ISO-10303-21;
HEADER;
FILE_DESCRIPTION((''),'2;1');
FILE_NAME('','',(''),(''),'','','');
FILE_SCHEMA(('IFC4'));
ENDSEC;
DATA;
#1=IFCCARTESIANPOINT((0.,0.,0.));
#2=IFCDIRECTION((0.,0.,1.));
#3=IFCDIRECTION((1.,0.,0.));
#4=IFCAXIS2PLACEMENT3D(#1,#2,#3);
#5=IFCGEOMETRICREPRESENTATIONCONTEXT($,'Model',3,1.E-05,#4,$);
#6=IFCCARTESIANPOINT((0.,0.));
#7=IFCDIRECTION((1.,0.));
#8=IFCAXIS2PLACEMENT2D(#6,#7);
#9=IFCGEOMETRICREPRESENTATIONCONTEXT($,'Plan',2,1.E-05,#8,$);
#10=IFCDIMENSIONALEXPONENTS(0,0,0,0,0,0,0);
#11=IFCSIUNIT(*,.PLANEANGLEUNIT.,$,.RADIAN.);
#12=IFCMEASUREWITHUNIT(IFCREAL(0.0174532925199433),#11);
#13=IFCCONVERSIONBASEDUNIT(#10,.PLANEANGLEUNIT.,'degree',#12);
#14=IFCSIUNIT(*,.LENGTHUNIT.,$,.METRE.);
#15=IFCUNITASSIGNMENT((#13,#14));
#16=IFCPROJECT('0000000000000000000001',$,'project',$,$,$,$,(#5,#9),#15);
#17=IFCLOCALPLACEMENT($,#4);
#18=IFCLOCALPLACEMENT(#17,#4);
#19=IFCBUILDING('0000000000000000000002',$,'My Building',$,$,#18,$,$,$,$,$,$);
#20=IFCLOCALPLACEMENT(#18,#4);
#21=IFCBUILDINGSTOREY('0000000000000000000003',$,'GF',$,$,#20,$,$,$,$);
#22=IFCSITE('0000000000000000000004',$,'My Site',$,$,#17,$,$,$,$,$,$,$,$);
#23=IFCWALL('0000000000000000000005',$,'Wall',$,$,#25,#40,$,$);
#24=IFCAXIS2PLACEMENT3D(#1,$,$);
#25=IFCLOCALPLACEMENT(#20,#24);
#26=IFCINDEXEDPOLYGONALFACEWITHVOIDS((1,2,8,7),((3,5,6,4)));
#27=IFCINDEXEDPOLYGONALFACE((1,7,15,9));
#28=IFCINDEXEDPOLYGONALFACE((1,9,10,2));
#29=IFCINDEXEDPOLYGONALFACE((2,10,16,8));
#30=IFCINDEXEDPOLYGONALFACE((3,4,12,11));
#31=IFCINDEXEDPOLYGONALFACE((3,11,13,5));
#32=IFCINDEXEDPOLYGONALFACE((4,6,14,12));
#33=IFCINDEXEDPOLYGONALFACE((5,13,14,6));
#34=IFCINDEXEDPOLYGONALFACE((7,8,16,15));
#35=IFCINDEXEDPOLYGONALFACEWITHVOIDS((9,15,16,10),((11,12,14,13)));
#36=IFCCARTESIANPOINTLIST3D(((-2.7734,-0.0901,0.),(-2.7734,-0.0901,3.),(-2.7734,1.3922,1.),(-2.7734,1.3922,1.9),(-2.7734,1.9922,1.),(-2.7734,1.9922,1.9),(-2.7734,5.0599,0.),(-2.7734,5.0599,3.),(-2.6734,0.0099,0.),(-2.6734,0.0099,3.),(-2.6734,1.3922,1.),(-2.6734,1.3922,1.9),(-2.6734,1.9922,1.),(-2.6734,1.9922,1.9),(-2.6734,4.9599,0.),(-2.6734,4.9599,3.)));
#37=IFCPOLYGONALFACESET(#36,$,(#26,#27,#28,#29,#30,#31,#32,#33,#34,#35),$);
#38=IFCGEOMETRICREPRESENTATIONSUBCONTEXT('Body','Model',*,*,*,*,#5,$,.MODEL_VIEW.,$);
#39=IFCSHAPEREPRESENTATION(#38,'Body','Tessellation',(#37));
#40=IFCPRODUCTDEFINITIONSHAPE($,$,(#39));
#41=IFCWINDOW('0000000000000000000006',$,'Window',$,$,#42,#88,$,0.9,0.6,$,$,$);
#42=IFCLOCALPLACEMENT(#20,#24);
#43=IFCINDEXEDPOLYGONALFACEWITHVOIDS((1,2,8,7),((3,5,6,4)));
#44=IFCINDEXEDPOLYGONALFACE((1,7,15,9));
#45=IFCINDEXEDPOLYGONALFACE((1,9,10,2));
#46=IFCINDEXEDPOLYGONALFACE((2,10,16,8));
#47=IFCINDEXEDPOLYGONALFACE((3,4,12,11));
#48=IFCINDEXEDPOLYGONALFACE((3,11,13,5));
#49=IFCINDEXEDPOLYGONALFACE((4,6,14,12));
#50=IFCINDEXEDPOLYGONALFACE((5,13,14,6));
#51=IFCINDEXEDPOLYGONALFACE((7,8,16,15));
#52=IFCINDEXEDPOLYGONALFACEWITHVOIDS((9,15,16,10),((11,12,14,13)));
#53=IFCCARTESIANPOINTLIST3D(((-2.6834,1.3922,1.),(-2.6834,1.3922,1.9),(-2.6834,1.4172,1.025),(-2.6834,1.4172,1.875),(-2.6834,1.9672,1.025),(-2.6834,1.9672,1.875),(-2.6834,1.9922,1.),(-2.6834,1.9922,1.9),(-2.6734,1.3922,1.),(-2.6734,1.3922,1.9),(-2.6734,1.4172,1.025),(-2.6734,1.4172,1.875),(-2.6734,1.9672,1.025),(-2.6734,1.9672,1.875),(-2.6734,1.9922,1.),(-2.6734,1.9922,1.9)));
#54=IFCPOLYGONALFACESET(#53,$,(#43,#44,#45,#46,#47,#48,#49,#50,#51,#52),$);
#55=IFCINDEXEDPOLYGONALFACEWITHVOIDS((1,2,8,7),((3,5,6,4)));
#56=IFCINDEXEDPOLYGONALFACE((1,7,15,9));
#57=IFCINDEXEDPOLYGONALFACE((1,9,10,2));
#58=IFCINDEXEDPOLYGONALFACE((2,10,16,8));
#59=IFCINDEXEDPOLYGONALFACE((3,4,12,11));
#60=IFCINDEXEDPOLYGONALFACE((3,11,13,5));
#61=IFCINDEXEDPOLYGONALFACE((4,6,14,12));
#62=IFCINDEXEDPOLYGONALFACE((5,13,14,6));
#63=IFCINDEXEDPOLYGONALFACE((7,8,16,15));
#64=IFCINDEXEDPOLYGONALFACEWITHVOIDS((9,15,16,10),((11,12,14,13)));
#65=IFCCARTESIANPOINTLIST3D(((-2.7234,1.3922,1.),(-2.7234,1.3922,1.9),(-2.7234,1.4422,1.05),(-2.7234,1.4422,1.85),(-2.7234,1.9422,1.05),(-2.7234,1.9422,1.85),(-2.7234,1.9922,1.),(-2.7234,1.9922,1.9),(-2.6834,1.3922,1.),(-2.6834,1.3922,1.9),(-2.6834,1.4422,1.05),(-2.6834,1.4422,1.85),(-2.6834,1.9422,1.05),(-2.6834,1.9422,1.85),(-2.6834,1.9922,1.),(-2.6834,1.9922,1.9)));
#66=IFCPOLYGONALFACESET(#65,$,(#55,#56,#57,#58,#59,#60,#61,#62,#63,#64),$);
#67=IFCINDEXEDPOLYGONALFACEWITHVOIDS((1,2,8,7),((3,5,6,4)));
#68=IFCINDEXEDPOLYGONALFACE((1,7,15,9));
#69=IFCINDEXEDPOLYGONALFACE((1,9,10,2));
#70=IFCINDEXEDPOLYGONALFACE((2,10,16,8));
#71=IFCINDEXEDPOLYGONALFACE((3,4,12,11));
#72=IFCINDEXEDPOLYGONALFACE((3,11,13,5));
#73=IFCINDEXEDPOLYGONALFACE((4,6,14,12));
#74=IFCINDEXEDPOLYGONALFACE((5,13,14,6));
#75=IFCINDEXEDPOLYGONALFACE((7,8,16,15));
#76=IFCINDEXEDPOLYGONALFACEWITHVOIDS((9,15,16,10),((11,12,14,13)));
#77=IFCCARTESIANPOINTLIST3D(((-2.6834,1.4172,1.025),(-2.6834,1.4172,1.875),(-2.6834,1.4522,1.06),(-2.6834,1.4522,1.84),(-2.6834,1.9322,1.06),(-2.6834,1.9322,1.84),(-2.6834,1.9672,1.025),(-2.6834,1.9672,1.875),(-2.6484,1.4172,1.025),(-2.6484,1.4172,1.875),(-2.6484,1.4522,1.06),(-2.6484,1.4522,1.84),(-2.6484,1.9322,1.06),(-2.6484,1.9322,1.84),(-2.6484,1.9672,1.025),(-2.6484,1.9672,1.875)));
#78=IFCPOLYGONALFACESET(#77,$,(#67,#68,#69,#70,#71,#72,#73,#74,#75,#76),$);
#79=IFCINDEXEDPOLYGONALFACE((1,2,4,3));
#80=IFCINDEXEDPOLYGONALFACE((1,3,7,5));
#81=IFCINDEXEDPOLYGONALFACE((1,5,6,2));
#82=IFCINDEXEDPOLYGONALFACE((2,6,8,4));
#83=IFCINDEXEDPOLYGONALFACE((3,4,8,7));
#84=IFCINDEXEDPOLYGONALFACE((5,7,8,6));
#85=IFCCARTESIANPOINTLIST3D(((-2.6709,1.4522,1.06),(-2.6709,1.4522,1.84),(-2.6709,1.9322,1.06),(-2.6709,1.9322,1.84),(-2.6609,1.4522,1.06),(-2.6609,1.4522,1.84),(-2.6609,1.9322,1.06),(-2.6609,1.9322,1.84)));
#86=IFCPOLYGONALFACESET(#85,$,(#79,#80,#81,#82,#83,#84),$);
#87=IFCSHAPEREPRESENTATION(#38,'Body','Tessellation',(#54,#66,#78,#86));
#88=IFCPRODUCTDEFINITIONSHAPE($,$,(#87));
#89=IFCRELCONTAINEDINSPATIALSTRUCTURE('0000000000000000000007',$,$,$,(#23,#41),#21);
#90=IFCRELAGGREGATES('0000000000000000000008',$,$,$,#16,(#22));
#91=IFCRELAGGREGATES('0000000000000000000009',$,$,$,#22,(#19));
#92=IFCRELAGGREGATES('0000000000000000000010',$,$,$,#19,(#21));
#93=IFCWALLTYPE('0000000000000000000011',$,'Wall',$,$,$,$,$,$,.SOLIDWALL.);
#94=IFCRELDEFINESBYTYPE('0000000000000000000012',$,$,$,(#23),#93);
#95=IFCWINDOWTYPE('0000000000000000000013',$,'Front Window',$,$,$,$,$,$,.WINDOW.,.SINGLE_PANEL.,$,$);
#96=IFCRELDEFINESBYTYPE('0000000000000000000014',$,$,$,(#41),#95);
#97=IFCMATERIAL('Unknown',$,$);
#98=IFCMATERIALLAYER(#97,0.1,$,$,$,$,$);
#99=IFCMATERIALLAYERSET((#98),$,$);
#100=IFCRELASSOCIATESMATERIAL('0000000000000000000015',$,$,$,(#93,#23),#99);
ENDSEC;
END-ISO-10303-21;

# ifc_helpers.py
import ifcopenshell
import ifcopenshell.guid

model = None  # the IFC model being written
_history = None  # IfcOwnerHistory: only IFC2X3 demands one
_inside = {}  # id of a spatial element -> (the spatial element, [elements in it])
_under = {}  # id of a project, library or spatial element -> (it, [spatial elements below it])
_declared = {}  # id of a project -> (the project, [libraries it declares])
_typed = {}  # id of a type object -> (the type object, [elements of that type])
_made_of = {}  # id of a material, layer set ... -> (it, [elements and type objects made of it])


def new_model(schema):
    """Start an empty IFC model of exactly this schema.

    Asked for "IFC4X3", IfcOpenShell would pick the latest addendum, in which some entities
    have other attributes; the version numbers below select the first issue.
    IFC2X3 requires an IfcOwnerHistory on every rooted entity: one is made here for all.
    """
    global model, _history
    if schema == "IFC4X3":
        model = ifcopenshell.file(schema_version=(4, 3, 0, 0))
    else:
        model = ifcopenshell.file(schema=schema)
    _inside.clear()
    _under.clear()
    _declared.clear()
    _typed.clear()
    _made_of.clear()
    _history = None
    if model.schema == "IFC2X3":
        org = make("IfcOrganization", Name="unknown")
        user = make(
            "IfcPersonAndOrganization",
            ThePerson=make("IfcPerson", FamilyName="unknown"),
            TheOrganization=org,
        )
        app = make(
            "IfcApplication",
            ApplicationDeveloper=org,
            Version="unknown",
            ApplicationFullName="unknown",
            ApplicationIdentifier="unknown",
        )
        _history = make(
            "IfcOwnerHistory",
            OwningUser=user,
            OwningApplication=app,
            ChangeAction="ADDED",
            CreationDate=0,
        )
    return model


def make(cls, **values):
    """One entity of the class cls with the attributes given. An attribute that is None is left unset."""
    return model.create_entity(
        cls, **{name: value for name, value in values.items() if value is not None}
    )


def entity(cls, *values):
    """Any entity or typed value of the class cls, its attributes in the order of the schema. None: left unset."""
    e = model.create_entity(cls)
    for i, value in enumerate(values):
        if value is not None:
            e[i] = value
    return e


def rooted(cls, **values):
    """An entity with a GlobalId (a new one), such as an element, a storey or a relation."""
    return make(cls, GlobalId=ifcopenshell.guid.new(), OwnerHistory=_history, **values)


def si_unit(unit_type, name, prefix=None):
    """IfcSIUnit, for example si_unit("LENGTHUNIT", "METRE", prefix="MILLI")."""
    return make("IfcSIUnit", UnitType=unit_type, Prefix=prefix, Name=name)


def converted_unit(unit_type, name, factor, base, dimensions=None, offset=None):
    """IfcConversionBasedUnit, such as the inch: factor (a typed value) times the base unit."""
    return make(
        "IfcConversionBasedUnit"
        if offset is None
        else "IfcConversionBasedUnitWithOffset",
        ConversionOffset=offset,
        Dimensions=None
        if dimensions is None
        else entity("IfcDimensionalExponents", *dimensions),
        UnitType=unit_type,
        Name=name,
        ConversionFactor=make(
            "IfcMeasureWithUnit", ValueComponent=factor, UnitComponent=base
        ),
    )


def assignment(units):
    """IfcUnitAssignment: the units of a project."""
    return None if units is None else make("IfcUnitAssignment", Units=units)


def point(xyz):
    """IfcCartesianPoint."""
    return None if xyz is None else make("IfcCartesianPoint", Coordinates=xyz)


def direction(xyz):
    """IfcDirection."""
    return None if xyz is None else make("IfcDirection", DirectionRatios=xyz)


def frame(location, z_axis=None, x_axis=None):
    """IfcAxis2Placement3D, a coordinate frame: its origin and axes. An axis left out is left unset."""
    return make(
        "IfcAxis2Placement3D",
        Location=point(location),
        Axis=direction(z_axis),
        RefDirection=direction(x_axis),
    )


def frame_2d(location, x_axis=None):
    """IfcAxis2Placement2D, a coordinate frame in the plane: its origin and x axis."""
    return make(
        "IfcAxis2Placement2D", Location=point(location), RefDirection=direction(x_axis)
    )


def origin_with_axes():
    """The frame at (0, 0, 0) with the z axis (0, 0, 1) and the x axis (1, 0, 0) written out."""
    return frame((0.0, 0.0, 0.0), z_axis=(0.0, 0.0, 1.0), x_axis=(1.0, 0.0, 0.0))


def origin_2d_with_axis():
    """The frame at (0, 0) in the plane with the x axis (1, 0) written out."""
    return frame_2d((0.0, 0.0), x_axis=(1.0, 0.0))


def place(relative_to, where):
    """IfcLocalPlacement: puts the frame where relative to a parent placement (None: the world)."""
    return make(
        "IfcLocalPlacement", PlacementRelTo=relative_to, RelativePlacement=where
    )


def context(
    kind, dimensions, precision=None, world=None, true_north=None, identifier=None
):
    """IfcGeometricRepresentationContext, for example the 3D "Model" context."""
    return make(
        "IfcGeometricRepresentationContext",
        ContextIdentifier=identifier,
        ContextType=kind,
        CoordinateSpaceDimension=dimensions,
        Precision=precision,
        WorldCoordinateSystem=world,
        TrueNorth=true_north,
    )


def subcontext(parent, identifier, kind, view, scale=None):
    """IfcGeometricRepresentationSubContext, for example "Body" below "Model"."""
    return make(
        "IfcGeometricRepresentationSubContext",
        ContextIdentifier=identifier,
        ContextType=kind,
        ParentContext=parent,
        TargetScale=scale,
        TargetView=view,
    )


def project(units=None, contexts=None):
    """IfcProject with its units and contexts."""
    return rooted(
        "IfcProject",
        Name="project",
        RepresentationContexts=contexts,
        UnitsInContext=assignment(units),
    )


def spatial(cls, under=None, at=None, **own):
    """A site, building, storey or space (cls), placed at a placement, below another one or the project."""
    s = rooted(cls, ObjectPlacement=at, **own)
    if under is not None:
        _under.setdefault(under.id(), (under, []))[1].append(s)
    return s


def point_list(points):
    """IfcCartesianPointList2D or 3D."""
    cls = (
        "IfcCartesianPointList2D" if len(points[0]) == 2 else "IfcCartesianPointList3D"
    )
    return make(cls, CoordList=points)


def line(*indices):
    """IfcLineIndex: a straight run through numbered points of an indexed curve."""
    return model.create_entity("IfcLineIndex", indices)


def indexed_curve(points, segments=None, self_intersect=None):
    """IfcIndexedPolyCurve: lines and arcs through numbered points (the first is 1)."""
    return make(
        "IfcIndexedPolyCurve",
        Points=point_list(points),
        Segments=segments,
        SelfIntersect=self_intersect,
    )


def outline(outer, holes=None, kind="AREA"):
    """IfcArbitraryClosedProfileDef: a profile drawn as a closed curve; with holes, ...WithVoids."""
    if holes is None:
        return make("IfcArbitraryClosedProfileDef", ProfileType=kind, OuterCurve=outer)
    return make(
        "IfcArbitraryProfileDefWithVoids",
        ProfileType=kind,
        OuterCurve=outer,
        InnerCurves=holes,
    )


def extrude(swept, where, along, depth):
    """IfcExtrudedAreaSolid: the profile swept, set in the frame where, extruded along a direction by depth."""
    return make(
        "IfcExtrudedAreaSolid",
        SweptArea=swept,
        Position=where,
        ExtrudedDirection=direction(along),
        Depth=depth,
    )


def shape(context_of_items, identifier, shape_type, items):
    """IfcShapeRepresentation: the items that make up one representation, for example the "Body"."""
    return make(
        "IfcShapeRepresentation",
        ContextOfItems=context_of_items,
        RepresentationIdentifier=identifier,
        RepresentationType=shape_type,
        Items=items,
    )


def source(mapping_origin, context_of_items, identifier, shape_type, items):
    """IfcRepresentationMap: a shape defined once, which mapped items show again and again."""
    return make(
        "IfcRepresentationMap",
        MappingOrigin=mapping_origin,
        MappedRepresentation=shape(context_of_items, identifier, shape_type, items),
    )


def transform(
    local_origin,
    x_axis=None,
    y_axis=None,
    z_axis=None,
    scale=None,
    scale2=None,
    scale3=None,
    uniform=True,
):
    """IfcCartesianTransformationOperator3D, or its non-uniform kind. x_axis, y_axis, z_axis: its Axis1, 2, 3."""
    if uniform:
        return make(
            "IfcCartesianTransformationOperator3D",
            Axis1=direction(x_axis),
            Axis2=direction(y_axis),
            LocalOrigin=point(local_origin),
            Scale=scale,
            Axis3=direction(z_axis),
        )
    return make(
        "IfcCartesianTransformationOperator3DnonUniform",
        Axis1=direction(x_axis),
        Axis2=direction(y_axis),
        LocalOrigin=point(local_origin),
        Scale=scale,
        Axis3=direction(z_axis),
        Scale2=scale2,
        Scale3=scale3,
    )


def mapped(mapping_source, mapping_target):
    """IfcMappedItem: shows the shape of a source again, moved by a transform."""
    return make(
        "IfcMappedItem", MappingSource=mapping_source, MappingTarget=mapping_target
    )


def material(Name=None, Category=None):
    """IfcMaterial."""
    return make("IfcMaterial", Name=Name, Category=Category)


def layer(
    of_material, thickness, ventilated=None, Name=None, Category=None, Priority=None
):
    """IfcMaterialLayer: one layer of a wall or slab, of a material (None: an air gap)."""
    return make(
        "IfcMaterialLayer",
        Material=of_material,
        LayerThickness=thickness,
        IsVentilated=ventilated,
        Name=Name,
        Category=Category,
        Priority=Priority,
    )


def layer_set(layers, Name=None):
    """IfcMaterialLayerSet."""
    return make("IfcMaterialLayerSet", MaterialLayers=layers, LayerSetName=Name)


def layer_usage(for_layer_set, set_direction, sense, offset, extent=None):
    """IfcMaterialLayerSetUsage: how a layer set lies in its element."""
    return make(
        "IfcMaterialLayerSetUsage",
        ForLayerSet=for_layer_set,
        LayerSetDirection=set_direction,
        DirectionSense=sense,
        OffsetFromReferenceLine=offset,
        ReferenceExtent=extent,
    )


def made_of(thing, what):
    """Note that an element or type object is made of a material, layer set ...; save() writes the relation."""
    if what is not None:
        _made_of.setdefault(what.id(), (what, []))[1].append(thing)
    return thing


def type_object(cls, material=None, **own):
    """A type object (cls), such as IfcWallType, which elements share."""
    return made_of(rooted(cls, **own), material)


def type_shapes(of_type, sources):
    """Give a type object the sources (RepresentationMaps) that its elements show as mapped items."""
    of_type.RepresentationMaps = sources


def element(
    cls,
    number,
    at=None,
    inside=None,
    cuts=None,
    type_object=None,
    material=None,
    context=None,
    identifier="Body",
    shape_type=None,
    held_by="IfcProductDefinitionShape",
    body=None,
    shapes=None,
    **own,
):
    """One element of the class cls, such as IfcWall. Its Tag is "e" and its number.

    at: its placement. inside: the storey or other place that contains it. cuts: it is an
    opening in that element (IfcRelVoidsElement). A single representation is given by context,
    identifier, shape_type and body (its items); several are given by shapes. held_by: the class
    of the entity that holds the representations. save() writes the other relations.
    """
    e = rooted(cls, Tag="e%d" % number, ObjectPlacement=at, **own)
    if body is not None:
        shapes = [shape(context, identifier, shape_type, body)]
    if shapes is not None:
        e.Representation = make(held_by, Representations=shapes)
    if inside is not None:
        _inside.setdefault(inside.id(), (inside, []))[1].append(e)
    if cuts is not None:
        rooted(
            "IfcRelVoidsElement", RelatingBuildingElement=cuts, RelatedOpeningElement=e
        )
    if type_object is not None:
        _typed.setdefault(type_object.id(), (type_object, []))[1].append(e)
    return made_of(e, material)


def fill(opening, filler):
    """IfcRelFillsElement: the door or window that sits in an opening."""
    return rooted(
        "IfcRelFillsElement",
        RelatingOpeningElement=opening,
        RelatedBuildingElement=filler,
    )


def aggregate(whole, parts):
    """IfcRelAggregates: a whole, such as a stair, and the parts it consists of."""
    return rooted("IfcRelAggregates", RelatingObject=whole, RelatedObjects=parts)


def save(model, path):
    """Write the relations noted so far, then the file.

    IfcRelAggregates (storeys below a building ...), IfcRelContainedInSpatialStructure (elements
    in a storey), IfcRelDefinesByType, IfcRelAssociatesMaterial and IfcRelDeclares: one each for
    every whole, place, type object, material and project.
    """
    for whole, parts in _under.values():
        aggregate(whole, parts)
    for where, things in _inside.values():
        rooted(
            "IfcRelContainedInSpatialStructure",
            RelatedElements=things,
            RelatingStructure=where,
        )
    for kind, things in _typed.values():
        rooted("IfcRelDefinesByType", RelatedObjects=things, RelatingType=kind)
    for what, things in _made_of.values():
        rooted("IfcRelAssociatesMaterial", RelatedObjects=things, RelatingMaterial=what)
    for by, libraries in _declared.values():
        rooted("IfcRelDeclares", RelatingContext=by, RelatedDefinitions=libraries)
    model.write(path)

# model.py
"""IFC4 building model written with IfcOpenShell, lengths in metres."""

from ifc_helpers import new_model, entity, si_unit, converted_unit, frame, origin_with_axes, origin_2d_with_axis, place, context, subcontext, project, spatial, line, indexed_curve, outline, extrude, shape, source, transform, mapped, material, layer, layer_set, layer_usage, type_object, type_shapes, element, fill, save


model = new_model("IFC4")

# Units and contexts
model_context = context("Model", 3, precision=1e-05, world=origin_with_axes())
plan_context = context("Plan", 2, precision=1e-05, world=origin_2d_with_axis())
body_context_1 = subcontext(model_context, "Body", "Model", "MODEL_VIEW")
body_context_2 = subcontext(plan_context, "Body", "Plan", "PLAN_VIEW")
ifc_project = project(units=[converted_unit("PLANEANGLEUNIT", "degree", entity("IfcReal", 0.0174532925199433), si_unit("PLANEANGLEUNIT", "RADIAN"), dimensions=[0, 0, 0, 0, 0, 0, 0]), si_unit("LENGTHUNIT", "METRE")], contexts=[model_context, plan_context])

# Site, building, storey
site_placement = place(None, origin_with_axes())
site = spatial("IfcSite", under=ifc_project, at=site_placement, Name="My Site")
building_placement = place(site_placement, origin_with_axes())
building = spatial("IfcBuilding", under=site, at=building_placement, Name="My Building")
storey_placement = place(building_placement, origin_with_axes())
storey = spatial("IfcBuildingStorey", under=building, at=storey_placement, Name="GF")

# Shared definitions
ifc_material = material(Name="Unknown")

# Shared definitions
ifc_layer_1 = layer(ifc_material, 0.1)
ifc_layer_set_1 = layer_set([ifc_layer_1])
wall_type = type_object("IfcWallType", Name="Wall", PredefinedType="SOLIDWALL", material=ifc_layer_set_1)
shared_shape_1 = source(origin_with_axes(), body_context_1, "Body", "SweptSolid", [
    extrude(outline(indexed_curve([(0.0, 0.0), (0.6, 0.0), (0.6, 0.9), (0.0, 0.9)], segments=[line(1, 2, 3, 4, 1)])), frame((0.0, -0.6, 0.0), z_axis=(0.0, -1.0, 0.0), x_axis=(1.0, 0.0, 0.0)), (0.0, 0.0, -1.0), 1.2),
])
window_type_1 = type_object("IfcWindowType", Name="Front Window", PartitioningType="SINGLE_PANEL", PredefinedType="WINDOW")
shared_shape_2 = source(origin_with_axes(), body_context_1, "Body", "SweptSolid", [
    extrude(outline(indexed_curve([(0.0, 0.0), (0.6, 0.0), (0.6, 0.9), (0.0, 0.9)], segments=[line(1, 2, 3, 4, 1)]), holes=[indexed_curve([(0.025, 0.025), (0.575, 0.025), (0.575, 0.875), (0.025, 0.875)], segments=[line(1, 2, 3, 4, 1)])]), frame((0.0, 0.09, 0.0), z_axis=(0.0, -1.0, 0.0), x_axis=(1.0, 0.0, 0.0)), (0.0, 0.0, -1.0), 0.01),
    extrude(outline(indexed_curve([(0.0, 0.0), (0.6, 0.0), (0.6, 0.9), (0.0, 0.9)], segments=[line(1, 2, 3, 4, 1)]), holes=[indexed_curve([(0.05, 0.05), (0.55, 0.05), (0.55, 0.85), (0.05, 0.85)], segments=[line(1, 2, 3, 4, 1)])]), frame((0.0, 0.05, 0.0), z_axis=(0.0, -1.0, 0.0), x_axis=(1.0, 0.0, 0.0)), (0.0, 0.0, -1.0), 0.04),
    extrude(outline(indexed_curve([(0.0, 0.0), (0.55, 0.0), (0.55, 0.85), (0.0, 0.85)], segments=[line(1, 2, 3, 4, 1)]), holes=[indexed_curve([(0.035, 0.035), (0.515, 0.035), (0.515, 0.815), (0.035, 0.815)], segments=[line(1, 2, 3, 4, 1)])]), frame((0.025, 0.09, 0.025), z_axis=(0.0, -1.0, 0.0), x_axis=(1.0, 0.0, 0.0)), (0.0, 0.0, -1.0), 0.035),
    extrude(outline(indexed_curve([(0.035, 0.035), (0.515, 0.035), (0.515, 0.815), (0.035, 0.815)], segments=[line(1, 2, 3, 4, 1)])), frame((0.025, 0.1025, 0.025), z_axis=(0.0, -1.0, 0.0), x_axis=(1.0, 0.0, 0.0)), (0.0, 0.0, -1.0), 0.01),
])
shared_shape_3 = source(origin_with_axes(), body_context_2, "Body", "Curve2D", [
    entity("IfcIndexedPolyCurve", entity("IfcCartesianPointList2D", [[0.05, 0.05], [0.55, 0.05]])),
    entity("IfcIndexedPolyCurve", entity("IfcCartesianPointList2D", [[0.0, 0.1], [0.025, 0.1], [0.025, 0.09], [0.05, 0.09], [0.05, 0.05], [0.0, 0.05]]), [entity("IfcLineIndex", [1, 2, 3, 4, 5, 6, 1])]),
    entity("IfcIndexedPolyCurve", entity("IfcCartesianPointList2D", [[0.6, 0.1], [0.575, 0.1], [0.575, 0.09], [0.55, 0.09], [0.55, 0.05], [0.6, 0.05]]), [entity("IfcLineIndex", [1, 2, 3, 4, 5, 6, 1])]),
    entity("IfcIndexedPolyCurve", entity("IfcCartesianPointList2D", [[0.025, 0.09], [0.06, 0.09], [0.06, 0.125], [0.025, 0.125]]), [entity("IfcLineIndex", [1, 2, 3, 4, 1])]),
    entity("IfcIndexedPolyCurve", entity("IfcCartesianPointList2D", [[0.575, 0.09], [0.54, 0.09], [0.54, 0.125], [0.575, 0.125]]), [entity("IfcLineIndex", [1, 2, 3, 4, 1])]),
    entity("IfcIndexedPolyCurve", entity("IfcCartesianPointList2D", [[0.06, 0.09], [0.54, 0.09]])),
    entity("IfcIndexedPolyCurve", entity("IfcCartesianPointList2D", [[0.06, 0.125], [0.54, 0.125]])),
    entity("IfcIndexedPolyCurve", entity("IfcCartesianPointList2D", [[0.06, 0.1075], [0.54, 0.1075]])),
])
type_shapes(window_type_1, [shared_shape_2, shared_shape_3])

# Wall, opening, window
ifc_layer_usage_1 = layer_usage(ifc_layer_set_1, "AXIS2", "POSITIVE", 0.0)
wall_1_placement = place(storey_placement, frame((-2.7734, 5.0599, 0.0), z_axis=(0.0, 0.0, 1.0), x_axis=(0.0, -1.0, 0.0)))
wall_1 = element("IfcWall", 1, at=wall_1_placement, inside=storey, type_object=wall_type, material=ifc_layer_usage_1, Name="Wall", context=body_context_1, shape_type="SweptSolid", body=[
    extrude(outline(indexed_curve([(0.0, 0.0), (0.1, 0.1), (5.05, 0.1), (5.15, 0.0)], segments=[line(1, 2, 3, 4, 1)])), origin_with_axes(), (0.0, 0.0, 1.0), 3.0),
])
opening_1_placement = place(wall_1_placement, frame((3.0677, 0.0, 1.0), z_axis=(0.0, 0.0, 1.0), x_axis=(1.0, 0.0, 0.0)))
opening_1 = element("IfcOpeningElement", 2, at=opening_1_placement, cuts=wall_1, PredefinedType="OPENING", context=body_context_1, shape_type="MappedRepresentation", body=[
    mapped(shared_shape_1, transform((0.0, 0.0, 0.0), x_axis=(1.0, 0.0, 0.0), y_axis=(0.0, 1.0, 0.0), z_axis=(0.0, 0.0, 1.0), scale=1.0)),
])
window_1_placement = place(opening_1_placement, frame((0.0, 0.0, 0.0), z_axis=(0.0, 0.0, 1.0), x_axis=(1.0, 0.0, 0.0)))
window_1 = element("IfcWindow", 3, at=window_1_placement, inside=storey, type_object=window_type_1, Name="Window", OverallHeight=0.9, OverallWidth=0.6, shapes=[
    shape(body_context_1, "Body", "MappedRepresentation", [mapped(shared_shape_2, transform((0.0, 0.0, 0.0), x_axis=(1.0, 0.0, 0.0), y_axis=(0.0, 1.0, 0.0), z_axis=(0.0, 0.0, 1.0), scale=1.0))]),
    shape(body_context_2, "Body", "MappedRepresentation", [mapped(shared_shape_3, transform((0.0, 0.0, 0.0), x_axis=(1.0, 0.0, 0.0), y_axis=(0.0, 1.0, 0.0), z_axis=(0.0, 0.0, 1.0), scale=1.0))]),
])
fill(opening_1, window_1)

save(model, "model.ifc")
